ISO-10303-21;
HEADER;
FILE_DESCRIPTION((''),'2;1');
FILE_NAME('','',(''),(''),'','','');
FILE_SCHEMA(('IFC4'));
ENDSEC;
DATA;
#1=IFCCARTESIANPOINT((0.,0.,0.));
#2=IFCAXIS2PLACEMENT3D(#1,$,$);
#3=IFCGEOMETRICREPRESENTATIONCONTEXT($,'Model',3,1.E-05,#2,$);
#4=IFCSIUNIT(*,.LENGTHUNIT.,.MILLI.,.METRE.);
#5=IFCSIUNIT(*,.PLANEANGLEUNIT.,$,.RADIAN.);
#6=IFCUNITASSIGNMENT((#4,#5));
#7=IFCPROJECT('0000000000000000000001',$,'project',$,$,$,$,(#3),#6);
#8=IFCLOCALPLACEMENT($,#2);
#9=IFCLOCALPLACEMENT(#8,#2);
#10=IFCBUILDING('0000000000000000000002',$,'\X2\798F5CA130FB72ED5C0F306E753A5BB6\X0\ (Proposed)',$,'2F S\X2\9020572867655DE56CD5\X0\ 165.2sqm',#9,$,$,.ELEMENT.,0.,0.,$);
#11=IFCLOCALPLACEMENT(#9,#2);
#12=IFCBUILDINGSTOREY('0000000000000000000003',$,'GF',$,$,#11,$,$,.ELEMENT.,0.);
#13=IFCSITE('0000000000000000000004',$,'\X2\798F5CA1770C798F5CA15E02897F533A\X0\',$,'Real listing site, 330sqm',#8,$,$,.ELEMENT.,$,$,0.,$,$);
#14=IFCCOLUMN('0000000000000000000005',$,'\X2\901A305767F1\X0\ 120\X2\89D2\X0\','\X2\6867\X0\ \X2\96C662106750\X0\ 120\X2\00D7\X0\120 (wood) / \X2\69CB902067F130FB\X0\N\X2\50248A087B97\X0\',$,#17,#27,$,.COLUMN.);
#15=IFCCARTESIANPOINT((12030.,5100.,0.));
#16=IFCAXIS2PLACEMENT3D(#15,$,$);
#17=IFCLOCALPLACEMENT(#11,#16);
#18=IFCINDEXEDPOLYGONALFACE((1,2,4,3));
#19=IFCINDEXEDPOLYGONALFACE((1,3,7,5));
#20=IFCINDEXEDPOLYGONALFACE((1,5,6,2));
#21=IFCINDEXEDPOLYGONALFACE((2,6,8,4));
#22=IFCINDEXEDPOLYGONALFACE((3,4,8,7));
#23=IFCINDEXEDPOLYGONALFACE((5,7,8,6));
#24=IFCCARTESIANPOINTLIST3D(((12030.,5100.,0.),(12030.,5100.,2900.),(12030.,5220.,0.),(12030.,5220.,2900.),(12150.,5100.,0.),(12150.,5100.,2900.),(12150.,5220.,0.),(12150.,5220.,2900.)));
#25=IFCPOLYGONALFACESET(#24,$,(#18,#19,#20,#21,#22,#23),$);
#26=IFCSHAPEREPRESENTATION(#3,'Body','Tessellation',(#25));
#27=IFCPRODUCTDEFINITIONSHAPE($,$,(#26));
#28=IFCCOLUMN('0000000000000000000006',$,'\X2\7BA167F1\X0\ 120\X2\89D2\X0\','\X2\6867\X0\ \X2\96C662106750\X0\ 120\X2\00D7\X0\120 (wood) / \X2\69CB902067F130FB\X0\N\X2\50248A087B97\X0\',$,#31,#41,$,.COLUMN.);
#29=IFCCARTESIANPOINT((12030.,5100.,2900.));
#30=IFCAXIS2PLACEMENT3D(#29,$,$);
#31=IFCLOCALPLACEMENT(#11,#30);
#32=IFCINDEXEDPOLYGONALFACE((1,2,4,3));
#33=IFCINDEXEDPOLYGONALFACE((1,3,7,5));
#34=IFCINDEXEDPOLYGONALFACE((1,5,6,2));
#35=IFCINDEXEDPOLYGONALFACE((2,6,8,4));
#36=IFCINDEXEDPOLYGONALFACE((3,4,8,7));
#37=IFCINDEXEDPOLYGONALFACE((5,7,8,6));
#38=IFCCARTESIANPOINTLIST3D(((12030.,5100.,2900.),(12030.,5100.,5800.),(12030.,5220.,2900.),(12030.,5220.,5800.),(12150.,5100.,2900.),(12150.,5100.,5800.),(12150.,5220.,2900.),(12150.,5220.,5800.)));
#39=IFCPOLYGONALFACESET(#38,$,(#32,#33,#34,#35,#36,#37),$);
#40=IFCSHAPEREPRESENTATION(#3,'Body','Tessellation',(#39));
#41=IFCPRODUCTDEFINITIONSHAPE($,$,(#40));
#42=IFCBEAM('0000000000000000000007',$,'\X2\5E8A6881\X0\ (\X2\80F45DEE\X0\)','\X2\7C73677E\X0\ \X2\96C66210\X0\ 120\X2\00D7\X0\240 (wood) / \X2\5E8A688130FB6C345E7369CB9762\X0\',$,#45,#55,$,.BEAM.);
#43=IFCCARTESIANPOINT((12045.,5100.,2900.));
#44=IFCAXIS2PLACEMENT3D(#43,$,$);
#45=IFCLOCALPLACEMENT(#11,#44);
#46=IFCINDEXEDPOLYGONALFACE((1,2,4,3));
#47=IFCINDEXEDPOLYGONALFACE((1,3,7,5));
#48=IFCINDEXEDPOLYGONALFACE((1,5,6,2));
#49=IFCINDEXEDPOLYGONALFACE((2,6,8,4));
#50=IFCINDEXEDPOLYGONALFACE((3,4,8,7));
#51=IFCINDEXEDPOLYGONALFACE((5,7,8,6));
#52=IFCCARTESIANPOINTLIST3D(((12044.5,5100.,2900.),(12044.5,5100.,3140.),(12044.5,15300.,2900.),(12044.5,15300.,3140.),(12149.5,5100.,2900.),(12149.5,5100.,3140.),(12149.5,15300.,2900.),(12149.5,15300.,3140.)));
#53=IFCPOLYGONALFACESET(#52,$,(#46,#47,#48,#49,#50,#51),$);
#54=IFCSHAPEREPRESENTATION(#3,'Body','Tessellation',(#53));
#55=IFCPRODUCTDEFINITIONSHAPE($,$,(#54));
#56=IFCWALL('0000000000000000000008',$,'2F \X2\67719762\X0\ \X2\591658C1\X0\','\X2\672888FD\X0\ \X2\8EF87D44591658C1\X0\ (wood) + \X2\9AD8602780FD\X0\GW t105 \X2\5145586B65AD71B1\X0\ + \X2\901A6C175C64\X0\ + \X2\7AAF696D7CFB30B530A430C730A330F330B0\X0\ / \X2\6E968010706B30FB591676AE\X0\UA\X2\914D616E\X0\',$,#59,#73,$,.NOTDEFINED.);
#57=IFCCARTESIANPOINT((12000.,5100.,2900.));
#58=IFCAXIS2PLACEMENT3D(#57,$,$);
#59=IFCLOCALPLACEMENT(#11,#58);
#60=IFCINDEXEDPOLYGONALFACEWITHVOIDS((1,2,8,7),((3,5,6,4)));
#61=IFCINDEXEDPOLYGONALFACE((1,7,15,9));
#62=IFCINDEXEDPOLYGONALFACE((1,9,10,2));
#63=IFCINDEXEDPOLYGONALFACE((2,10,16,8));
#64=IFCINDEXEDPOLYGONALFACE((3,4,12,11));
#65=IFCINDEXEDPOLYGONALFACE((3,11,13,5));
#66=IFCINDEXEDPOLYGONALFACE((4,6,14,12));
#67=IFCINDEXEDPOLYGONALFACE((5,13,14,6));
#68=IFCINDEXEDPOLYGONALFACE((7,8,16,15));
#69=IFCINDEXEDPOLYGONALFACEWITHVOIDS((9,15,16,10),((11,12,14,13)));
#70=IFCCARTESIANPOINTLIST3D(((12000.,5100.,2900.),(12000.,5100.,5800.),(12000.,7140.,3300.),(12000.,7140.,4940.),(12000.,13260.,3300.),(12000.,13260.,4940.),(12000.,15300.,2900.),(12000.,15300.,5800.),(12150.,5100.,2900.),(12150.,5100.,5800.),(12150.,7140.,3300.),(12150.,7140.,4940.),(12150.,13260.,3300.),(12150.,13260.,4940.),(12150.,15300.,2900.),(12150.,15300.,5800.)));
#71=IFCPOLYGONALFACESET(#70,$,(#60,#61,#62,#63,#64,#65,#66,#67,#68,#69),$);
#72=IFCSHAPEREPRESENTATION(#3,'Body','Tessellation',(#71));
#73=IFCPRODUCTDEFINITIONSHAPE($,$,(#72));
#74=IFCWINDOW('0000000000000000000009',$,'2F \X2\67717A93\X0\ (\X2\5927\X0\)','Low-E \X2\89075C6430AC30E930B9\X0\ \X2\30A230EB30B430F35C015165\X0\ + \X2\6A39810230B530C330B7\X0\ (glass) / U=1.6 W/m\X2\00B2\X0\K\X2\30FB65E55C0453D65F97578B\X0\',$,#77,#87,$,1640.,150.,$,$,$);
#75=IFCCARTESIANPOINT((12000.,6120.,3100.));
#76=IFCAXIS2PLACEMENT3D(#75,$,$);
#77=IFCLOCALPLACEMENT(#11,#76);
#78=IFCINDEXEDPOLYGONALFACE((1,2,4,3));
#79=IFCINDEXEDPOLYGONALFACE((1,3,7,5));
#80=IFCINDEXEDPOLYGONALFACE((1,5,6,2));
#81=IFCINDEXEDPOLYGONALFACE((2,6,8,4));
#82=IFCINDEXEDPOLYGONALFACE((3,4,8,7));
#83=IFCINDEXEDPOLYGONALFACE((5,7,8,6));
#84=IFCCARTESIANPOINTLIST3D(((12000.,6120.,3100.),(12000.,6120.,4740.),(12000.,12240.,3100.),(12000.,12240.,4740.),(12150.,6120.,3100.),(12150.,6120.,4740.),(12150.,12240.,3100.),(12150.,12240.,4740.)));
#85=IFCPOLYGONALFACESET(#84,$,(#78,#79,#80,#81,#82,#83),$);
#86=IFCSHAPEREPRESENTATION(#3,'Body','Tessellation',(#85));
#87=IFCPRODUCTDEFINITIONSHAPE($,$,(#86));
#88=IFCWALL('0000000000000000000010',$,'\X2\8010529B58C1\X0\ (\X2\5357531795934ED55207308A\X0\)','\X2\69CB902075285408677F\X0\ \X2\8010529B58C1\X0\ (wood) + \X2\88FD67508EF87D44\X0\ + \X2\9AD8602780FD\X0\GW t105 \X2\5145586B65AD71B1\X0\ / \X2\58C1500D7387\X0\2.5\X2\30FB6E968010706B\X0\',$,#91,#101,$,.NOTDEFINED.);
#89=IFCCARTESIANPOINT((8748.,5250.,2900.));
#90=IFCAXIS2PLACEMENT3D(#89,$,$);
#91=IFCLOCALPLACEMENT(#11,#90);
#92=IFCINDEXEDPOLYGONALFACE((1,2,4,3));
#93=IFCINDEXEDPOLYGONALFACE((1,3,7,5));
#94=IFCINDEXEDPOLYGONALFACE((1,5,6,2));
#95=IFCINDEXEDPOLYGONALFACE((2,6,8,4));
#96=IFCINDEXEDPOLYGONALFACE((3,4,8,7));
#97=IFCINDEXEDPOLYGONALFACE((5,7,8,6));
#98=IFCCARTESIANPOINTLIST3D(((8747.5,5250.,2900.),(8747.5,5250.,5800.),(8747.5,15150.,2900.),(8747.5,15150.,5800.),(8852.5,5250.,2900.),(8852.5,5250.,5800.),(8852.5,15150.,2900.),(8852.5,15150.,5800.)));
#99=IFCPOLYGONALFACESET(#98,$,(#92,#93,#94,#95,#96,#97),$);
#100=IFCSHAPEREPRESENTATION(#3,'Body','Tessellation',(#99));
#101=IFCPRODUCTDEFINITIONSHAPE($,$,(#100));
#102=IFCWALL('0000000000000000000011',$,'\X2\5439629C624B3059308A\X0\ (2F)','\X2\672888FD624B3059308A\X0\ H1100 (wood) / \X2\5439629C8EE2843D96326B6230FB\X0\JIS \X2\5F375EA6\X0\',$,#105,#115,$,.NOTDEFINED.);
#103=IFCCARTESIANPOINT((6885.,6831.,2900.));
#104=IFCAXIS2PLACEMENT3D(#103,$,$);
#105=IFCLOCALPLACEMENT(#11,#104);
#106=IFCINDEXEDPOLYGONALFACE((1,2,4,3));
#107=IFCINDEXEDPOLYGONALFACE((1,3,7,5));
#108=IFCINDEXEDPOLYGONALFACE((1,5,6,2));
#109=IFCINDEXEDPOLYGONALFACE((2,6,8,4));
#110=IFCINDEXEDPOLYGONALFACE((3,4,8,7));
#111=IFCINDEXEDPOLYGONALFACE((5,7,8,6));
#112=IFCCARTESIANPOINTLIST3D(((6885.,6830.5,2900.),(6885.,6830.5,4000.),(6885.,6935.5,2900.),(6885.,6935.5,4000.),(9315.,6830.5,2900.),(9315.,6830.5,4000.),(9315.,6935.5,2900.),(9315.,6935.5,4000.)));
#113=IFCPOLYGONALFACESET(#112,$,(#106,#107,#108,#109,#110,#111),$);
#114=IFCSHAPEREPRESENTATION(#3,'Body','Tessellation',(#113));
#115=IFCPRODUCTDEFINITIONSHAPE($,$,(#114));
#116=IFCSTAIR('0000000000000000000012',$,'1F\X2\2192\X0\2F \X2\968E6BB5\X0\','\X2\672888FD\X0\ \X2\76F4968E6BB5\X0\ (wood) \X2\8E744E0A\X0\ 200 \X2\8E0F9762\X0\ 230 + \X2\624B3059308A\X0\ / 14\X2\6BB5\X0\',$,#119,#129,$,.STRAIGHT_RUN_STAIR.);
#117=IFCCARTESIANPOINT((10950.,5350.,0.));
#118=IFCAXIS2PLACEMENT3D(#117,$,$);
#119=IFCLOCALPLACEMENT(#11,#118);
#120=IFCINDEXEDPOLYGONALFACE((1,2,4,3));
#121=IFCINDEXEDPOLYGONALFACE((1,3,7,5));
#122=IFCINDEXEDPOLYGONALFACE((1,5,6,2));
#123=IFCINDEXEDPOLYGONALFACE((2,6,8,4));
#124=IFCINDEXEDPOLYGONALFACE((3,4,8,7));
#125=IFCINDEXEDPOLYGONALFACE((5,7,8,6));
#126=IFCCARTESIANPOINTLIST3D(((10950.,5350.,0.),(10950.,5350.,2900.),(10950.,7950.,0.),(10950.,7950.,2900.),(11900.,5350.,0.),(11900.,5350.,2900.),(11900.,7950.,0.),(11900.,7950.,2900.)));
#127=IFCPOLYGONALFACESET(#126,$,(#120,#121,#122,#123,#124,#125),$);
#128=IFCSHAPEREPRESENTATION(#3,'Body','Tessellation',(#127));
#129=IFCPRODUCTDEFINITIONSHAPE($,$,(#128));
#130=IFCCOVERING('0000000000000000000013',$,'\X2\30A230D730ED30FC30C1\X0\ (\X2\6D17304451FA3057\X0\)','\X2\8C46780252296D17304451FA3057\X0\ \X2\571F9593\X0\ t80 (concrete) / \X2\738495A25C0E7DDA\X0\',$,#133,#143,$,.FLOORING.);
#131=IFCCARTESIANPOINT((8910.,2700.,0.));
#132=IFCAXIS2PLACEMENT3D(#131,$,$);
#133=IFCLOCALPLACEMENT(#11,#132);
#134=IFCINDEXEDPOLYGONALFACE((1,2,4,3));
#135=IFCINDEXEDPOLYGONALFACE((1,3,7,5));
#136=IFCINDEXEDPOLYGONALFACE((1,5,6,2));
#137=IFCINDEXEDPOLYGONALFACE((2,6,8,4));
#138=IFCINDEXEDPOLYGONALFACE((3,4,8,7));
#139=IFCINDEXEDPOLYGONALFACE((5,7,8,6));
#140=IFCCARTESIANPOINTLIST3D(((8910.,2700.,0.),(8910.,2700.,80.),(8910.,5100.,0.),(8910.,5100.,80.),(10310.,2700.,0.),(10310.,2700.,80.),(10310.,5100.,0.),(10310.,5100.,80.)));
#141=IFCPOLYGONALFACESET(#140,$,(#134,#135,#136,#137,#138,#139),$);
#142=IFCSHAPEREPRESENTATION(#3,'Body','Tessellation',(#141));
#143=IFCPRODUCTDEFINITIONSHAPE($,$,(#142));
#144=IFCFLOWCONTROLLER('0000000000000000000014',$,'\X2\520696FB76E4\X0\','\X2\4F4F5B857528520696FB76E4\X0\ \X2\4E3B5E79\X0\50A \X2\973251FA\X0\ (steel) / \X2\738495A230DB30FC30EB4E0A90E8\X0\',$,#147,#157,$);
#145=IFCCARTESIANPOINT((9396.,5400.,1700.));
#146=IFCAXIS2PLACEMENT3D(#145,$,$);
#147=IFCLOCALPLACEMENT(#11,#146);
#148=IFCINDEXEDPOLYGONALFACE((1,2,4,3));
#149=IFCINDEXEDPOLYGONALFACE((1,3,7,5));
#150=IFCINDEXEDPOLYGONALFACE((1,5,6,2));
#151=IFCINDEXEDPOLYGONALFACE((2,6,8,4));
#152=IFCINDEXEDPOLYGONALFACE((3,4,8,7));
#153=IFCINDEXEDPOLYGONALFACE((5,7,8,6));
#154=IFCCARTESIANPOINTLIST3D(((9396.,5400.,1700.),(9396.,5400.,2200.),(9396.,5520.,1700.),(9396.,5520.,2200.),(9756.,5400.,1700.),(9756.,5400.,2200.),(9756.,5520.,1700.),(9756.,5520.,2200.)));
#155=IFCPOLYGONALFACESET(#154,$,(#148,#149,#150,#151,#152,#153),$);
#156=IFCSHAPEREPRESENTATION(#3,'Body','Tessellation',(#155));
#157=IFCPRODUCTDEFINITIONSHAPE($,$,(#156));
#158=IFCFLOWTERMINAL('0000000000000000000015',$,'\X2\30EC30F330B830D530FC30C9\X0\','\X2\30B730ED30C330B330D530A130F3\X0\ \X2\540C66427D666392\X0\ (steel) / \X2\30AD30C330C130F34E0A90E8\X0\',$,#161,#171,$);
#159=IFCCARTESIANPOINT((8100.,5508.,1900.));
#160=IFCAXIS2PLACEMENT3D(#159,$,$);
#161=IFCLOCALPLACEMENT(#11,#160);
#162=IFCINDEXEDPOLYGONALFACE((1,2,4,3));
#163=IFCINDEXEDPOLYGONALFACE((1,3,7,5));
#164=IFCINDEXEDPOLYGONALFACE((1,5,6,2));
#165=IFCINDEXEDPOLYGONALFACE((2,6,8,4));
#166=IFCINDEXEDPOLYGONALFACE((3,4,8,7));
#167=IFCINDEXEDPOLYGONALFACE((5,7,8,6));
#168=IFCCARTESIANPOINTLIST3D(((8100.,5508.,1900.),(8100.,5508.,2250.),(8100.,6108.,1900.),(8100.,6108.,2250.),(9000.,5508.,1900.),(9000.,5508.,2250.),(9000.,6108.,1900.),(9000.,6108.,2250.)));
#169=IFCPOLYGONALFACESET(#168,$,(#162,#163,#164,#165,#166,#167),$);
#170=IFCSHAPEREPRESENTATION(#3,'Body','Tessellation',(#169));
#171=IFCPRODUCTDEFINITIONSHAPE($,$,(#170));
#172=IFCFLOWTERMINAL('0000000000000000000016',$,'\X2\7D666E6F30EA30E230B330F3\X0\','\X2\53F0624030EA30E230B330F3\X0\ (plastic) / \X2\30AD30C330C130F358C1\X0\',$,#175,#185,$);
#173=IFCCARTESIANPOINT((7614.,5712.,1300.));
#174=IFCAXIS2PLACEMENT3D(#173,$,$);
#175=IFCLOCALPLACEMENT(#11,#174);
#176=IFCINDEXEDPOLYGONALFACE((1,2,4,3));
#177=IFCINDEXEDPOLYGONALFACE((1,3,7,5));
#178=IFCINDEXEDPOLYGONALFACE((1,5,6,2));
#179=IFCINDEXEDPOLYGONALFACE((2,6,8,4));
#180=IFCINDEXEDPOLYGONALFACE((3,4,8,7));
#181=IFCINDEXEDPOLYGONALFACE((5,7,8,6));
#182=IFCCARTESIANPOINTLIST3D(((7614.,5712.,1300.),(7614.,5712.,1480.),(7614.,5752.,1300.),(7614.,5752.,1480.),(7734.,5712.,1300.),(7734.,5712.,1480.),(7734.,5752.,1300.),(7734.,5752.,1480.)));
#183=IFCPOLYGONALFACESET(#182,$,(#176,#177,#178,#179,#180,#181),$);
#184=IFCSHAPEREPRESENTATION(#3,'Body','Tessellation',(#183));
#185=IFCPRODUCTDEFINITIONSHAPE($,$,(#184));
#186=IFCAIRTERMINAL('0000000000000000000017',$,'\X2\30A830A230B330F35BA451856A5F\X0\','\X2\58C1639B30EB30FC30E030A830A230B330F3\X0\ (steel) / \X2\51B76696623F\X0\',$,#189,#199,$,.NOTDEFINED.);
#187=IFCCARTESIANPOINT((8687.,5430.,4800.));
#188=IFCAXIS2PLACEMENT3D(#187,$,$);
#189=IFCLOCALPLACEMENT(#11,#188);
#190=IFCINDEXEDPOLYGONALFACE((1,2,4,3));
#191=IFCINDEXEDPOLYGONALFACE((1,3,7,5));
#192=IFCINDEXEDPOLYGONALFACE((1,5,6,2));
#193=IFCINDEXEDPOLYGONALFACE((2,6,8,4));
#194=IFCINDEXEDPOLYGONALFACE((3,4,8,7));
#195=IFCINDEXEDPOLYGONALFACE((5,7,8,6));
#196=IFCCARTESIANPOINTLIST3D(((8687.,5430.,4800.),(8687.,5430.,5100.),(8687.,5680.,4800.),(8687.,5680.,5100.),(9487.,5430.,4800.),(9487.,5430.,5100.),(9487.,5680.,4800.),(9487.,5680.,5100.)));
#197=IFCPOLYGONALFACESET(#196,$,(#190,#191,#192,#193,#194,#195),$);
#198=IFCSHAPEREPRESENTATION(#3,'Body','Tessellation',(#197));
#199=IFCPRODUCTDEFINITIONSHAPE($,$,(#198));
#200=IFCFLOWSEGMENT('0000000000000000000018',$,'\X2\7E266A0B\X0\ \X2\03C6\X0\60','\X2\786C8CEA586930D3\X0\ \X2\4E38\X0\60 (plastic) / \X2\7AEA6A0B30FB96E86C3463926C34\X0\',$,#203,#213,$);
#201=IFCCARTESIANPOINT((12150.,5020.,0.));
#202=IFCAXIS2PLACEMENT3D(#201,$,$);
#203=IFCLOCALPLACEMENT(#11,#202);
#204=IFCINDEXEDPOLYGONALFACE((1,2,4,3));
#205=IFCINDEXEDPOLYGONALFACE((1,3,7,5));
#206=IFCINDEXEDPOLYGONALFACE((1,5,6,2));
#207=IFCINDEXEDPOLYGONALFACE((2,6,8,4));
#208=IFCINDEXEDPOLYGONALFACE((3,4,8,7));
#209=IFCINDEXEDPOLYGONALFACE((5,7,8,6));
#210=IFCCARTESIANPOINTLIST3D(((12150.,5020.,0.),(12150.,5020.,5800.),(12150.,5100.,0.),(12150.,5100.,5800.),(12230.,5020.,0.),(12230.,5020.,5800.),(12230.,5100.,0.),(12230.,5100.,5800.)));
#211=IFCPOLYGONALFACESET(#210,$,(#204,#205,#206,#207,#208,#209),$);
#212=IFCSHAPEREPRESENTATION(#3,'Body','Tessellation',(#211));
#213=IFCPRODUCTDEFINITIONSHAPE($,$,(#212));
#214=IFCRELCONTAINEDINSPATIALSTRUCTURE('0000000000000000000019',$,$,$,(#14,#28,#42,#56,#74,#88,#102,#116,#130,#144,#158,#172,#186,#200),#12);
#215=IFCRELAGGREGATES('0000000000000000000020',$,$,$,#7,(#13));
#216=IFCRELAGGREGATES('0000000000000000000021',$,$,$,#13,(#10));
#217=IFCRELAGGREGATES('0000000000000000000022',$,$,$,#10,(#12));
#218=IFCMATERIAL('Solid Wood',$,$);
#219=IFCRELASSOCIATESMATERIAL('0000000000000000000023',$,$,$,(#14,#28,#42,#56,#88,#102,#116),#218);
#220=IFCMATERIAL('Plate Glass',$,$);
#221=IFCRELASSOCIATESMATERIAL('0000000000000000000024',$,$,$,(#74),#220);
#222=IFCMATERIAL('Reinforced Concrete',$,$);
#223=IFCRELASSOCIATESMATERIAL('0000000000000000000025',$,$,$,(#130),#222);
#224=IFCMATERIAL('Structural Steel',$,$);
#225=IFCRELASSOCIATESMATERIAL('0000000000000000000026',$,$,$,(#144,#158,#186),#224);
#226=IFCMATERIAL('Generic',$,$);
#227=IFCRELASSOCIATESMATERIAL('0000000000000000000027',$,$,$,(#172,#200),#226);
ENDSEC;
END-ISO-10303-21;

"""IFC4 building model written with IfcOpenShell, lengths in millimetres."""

from ifc_helpers import new_model, si_unit, frame, frame_2d, origin, place, context, project, spatial, rectangle, extrude, material, element, fill, save


model = new_model("IFC4")

# Units and contexts
model_context = context("Model", 3, precision=1e-05, world=origin())
ifc_project = project(units=[si_unit("LENGTHUNIT", "METRE", prefix="MILLI"), si_unit("PLANEANGLEUNIT", "RADIAN")], contexts=[model_context])

# Site, building, storey
site_placement = place(None, origin())
site = spatial("IfcSite", under=ifc_project, at=site_placement, Name="福岡県福岡市西区", ObjectType="Real listing site, 330sqm", CompositionType="ELEMENT", RefElevation=0.0)
building_placement = place(site_placement, origin())
building = spatial("IfcBuilding", under=site, at=building_placement, Name="福岡・狭小の町家 (Proposed)", ObjectType="2F S造在来工法 165.2sqm", CompositionType="ELEMENT", ElevationOfRefHeight=0.0, ElevationOfTerrain=0.0)
storey_placement = place(building_placement, origin())
storey = spatial("IfcBuildingStorey", under=building, at=storey_placement, Name="GF", CompositionType="ELEMENT", Elevation=0.0)

# Columns
ifc_material_1 = material(Name="Solid Wood")
column_1_placement = place(storey_placement, frame((12030.0, 5100.0, 0.0)))
element("IfcColumn", 1, at=column_1_placement, inside=storey, material=ifc_material_1, Name="通し柱 120角", Description="桧 集成材 120×120 (wood) / 構造柱・N値計算", PredefinedType="COLUMN", context=model_context, shape_type="SweptSolid", body=[
    extrude(rectangle(XDim=120.0, YDim=120.0, at=frame_2d((60.0, 60.0))), frame((12030.0, 5100.0, 0.0)), (0.0, 0.0, 1.0), 2900.0),
])
column_2_placement = place(storey_placement, frame((12030.0, 5100.0, 2900.0)))
element("IfcColumn", 2, at=column_2_placement, inside=storey, material=ifc_material_1, Name="管柱 120角", Description="桧 集成材 120×120 (wood) / 構造柱・N値計算", PredefinedType="COLUMN", context=model_context, shape_type="SweptSolid", body=[
    extrude(rectangle(XDim=120.0, YDim=120.0, at=frame_2d((60.0, 60.0))), frame((12030.0, 5100.0, 2900.0)), (0.0, 0.0, 1.0), 2900.0),
])

# Beam
beam_1_placement = place(storey_placement, frame((12045.0, 5100.0, 2900.0)))
element("IfcBeam", 3, at=beam_1_placement, inside=storey, material=ifc_material_1, Name="床梁 (胴差)", Description="米松 集成 120×240 (wood) / 床梁・水平構面", PredefinedType="BEAM", context=model_context, shape_type="SweptSolid", body=[
    extrude(rectangle(XDim=105.0, YDim=10200.0, at=frame_2d((52.0, 5100.0))), frame((12045.0, 5100.0, 2900.0)), (0.0, 0.0, 1.0), 240.0),
])

# Shared definitions
ifc_material_2 = material(Name="Plate Glass")

# Wall, opening, window
wall_1_placement = place(storey_placement, frame((12000.0, 5100.0, 2900.0)))
wall_1 = element("IfcWall", 4, at=wall_1_placement, inside=storey, material=ifc_material_1, Name="2F 東面 外壁", Description="木製 軸組外壁 (wood) + 高性能GW t105 充填断熱 + 通気層 + 窯業系サイディング / 準耐火・外皮UA配慮", PredefinedType="NOTDEFINED", context=model_context, shape_type="SweptSolid", body=[
    extrude(rectangle(XDim=150.0, YDim=10200.0, at=frame_2d((75.0, 5100.0))), frame((12000.0, 5100.0, 2900.0)), (0.0, 0.0, 1.0), 2900.0),
])
opening_1_placement = place(storey_placement, frame((12000.0, 6120.0, 3100.0)))
opening_1 = element("IfcOpeningElement", 5, at=opening_1_placement, cuts=wall_1, PredefinedType="NOTDEFINED", context=model_context, shape_type="SweptSolid", body=[
    extrude(rectangle(XDim=150.0, YDim=6120.0, at=frame_2d((75.0, 3060.0))), frame((12000.0, 6120.0, 3100.0)), (0.0, 0.0, 1.0), 1640.0),
])
window_1_placement = place(storey_placement, frame((12000.0, 6120.0, 3100.0)))
window_1 = element("IfcWindow", 6, at=window_1_placement, inside=storey, material=ifc_material_2, Name="2F 東窓 (大)", Description="Low-E 複層ガラス アルゴン封入 + 樹脂サッシ (glass) / U=1.6 W/m²K・日射取得型", OverallHeight=1640.0, OverallWidth=150.0, context=model_context, shape_type="SweptSolid", body=[
    extrude(rectangle(XDim=150.0, YDim=6120.0, at=frame_2d((75.0, 3060.0))), frame((12000.0, 6120.0, 3100.0)), (0.0, 0.0, 1.0), 1640.0),
])
fill(opening_1, window_1)

# Walls
wall_2_placement = place(storey_placement, frame((8748.0, 5250.0, 2900.0)))
element("IfcWall", 7, at=wall_2_placement, inside=storey, material=ifc_material_1, Name="耐力壁 (南北間仕切り)", Description="構造用合板 耐力壁 (wood) + 製材軸組 + 高性能GW t105 充填断熱 / 壁倍率2.5・準耐火", PredefinedType="NOTDEFINED", context=model_context, shape_type="SweptSolid", body=[
    extrude(rectangle(XDim=105.0, YDim=9900.0, at=frame_2d((52.0, 4950.0))), frame((8748.0, 5250.0, 2900.0)), (0.0, 0.0, 1.0), 2900.0),
])
wall_3_placement = place(storey_placement, frame((6885.0, 6831.0, 2900.0)))
element("IfcWall", 8, at=wall_3_placement, inside=storey, material=ifc_material_1, Name="吹抜手すり (2F)", Description="木製手すり H1100 (wood) / 吹抜転落防止・JIS 強度", PredefinedType="NOTDEFINED", context=model_context, shape_type="SweptSolid", body=[
    extrude(rectangle(XDim=2430.0, YDim=105.0, at=frame_2d((1215.0, 52.0))), frame((6885.0, 6831.0, 2900.0)), (0.0, 0.0, 1.0), 1100.0),
])

# Stair
stair_placement = place(storey_placement, frame((10950.0, 5350.0, 0.0)))
element("IfcStair", 9, at=stair_placement, inside=storey, material=ifc_material_1, Name="1F→2F 階段", Description="木製 直階段 (wood) 蹴上 200 踏面 230 + 手すり / 14段", PredefinedType="STRAIGHT_RUN_STAIR", context=model_context, shape_type="SweptSolid", body=[
    extrude(rectangle(XDim=950.0, YDim=2600.0, at=frame_2d((475.0, 1300.0))), frame((10950.0, 5350.0, 0.0)), (0.0, 0.0, 1.0), 2900.0),
])

# Covering
ifc_material_3 = material(Name="Reinforced Concrete")
covering_placement = place(storey_placement, frame((8910.0, 2700.0, 0.0)))
element("IfcCovering", 10, at=covering_placement, inside=storey, material=ifc_material_3, Name="アプローチ (洗い出し)", Description="豆砂利洗い出し 土間 t80 (concrete) / 玄関導線", PredefinedType="FLOORING", context=model_context, shape_type="SweptSolid", body=[
    extrude(rectangle(XDim=1400.0, YDim=2400.0, at=frame_2d((700.0, 1200.0))), frame((8910.0, 2700.0, 0.0)), (0.0, 0.0, 1.0), 80.0),
])

# Flow controller
ifc_material_4 = material(Name="Structural Steel")
flow_controller_placement = place(storey_placement, frame((9396.0, 5400.0, 1700.0)))
element("IfcFlowController", 11, at=flow_controller_placement, inside=storey, material=ifc_material_4, Name="分電盤", Description="住宅用分電盤 主幹50A 露出 (steel) / 玄関ホール上部", context=model_context, shape_type="SweptSolid", body=[
    extrude(rectangle(XDim=360.0, YDim=120.0, at=frame_2d((180.0, 60.0))), frame((9396.0, 5400.0, 1700.0)), (0.0, 0.0, 1.0), 500.0),
])

# Flow terminals
flow_terminal_1_placement = place(storey_placement, frame((8100.0, 5508.0, 1900.0)))
element("IfcFlowTerminal", 12, at=flow_terminal_1_placement, inside=storey, material=ifc_material_4, Name="レンジフード", Description="シロッコファン 同時給排 (steel) / キッチン上部", context=model_context, shape_type="SweptSolid", body=[
    extrude(rectangle(XDim=900.0, YDim=600.0, at=frame_2d((450.0, 300.0))), frame((8100.0, 5508.0, 1900.0)), (0.0, 0.0, 1.0), 350.0),
])
ifc_material_5 = material(Name="Generic")
flow_terminal_2_placement = place(storey_placement, frame((7614.0, 5712.0, 1300.0)))
element("IfcFlowTerminal", 13, at=flow_terminal_2_placement, inside=storey, material=ifc_material_5, Name="給湯リモコン", Description="台所リモコン (plastic) / キッチン壁", context=model_context, shape_type="SweptSolid", body=[
    extrude(rectangle(XDim=120.0, YDim=40.0, at=frame_2d((60.0, 20.0))), frame((7614.0, 5712.0, 1300.0)), (0.0, 0.0, 1.0), 180.0),
])

# Air terminal
air_terminal_placement = place(storey_placement, frame((8687.0, 5430.0, 4800.0)))
element("IfcAirTerminal", 14, at=air_terminal_placement, inside=storey, material=ifc_material_4, Name="エアコン室内機", Description="壁掛ルームエアコン (steel) / 冷暖房", PredefinedType="NOTDEFINED", context=model_context, shape_type="SweptSolid", body=[
    extrude(rectangle(XDim=800.0, YDim=250.0, at=frame_2d((400.0, 125.0))), frame((8687.0, 5430.0, 4800.0)), (0.0, 0.0, 1.0), 300.0),
])

# Flow segment
flow_segment_placement = place(storey_placement, frame((12150.0, 5020.0, 0.0)))
element("IfcFlowSegment", 15, at=flow_segment_placement, inside=storey, material=ifc_material_5, Name="縦樋 φ60", Description="硬質塩ビ 丸60 (plastic) / 竪樋・雨水排水", context=model_context, shape_type="SweptSolid", body=[
    extrude(rectangle(XDim=80.0, YDim=80.0, at=frame_2d((40.0, 40.0))), frame((12150.0, 5020.0, 0.0)), (0.0, 0.0, 1.0), 5800.0),
])

save(model, "model.ifc")
